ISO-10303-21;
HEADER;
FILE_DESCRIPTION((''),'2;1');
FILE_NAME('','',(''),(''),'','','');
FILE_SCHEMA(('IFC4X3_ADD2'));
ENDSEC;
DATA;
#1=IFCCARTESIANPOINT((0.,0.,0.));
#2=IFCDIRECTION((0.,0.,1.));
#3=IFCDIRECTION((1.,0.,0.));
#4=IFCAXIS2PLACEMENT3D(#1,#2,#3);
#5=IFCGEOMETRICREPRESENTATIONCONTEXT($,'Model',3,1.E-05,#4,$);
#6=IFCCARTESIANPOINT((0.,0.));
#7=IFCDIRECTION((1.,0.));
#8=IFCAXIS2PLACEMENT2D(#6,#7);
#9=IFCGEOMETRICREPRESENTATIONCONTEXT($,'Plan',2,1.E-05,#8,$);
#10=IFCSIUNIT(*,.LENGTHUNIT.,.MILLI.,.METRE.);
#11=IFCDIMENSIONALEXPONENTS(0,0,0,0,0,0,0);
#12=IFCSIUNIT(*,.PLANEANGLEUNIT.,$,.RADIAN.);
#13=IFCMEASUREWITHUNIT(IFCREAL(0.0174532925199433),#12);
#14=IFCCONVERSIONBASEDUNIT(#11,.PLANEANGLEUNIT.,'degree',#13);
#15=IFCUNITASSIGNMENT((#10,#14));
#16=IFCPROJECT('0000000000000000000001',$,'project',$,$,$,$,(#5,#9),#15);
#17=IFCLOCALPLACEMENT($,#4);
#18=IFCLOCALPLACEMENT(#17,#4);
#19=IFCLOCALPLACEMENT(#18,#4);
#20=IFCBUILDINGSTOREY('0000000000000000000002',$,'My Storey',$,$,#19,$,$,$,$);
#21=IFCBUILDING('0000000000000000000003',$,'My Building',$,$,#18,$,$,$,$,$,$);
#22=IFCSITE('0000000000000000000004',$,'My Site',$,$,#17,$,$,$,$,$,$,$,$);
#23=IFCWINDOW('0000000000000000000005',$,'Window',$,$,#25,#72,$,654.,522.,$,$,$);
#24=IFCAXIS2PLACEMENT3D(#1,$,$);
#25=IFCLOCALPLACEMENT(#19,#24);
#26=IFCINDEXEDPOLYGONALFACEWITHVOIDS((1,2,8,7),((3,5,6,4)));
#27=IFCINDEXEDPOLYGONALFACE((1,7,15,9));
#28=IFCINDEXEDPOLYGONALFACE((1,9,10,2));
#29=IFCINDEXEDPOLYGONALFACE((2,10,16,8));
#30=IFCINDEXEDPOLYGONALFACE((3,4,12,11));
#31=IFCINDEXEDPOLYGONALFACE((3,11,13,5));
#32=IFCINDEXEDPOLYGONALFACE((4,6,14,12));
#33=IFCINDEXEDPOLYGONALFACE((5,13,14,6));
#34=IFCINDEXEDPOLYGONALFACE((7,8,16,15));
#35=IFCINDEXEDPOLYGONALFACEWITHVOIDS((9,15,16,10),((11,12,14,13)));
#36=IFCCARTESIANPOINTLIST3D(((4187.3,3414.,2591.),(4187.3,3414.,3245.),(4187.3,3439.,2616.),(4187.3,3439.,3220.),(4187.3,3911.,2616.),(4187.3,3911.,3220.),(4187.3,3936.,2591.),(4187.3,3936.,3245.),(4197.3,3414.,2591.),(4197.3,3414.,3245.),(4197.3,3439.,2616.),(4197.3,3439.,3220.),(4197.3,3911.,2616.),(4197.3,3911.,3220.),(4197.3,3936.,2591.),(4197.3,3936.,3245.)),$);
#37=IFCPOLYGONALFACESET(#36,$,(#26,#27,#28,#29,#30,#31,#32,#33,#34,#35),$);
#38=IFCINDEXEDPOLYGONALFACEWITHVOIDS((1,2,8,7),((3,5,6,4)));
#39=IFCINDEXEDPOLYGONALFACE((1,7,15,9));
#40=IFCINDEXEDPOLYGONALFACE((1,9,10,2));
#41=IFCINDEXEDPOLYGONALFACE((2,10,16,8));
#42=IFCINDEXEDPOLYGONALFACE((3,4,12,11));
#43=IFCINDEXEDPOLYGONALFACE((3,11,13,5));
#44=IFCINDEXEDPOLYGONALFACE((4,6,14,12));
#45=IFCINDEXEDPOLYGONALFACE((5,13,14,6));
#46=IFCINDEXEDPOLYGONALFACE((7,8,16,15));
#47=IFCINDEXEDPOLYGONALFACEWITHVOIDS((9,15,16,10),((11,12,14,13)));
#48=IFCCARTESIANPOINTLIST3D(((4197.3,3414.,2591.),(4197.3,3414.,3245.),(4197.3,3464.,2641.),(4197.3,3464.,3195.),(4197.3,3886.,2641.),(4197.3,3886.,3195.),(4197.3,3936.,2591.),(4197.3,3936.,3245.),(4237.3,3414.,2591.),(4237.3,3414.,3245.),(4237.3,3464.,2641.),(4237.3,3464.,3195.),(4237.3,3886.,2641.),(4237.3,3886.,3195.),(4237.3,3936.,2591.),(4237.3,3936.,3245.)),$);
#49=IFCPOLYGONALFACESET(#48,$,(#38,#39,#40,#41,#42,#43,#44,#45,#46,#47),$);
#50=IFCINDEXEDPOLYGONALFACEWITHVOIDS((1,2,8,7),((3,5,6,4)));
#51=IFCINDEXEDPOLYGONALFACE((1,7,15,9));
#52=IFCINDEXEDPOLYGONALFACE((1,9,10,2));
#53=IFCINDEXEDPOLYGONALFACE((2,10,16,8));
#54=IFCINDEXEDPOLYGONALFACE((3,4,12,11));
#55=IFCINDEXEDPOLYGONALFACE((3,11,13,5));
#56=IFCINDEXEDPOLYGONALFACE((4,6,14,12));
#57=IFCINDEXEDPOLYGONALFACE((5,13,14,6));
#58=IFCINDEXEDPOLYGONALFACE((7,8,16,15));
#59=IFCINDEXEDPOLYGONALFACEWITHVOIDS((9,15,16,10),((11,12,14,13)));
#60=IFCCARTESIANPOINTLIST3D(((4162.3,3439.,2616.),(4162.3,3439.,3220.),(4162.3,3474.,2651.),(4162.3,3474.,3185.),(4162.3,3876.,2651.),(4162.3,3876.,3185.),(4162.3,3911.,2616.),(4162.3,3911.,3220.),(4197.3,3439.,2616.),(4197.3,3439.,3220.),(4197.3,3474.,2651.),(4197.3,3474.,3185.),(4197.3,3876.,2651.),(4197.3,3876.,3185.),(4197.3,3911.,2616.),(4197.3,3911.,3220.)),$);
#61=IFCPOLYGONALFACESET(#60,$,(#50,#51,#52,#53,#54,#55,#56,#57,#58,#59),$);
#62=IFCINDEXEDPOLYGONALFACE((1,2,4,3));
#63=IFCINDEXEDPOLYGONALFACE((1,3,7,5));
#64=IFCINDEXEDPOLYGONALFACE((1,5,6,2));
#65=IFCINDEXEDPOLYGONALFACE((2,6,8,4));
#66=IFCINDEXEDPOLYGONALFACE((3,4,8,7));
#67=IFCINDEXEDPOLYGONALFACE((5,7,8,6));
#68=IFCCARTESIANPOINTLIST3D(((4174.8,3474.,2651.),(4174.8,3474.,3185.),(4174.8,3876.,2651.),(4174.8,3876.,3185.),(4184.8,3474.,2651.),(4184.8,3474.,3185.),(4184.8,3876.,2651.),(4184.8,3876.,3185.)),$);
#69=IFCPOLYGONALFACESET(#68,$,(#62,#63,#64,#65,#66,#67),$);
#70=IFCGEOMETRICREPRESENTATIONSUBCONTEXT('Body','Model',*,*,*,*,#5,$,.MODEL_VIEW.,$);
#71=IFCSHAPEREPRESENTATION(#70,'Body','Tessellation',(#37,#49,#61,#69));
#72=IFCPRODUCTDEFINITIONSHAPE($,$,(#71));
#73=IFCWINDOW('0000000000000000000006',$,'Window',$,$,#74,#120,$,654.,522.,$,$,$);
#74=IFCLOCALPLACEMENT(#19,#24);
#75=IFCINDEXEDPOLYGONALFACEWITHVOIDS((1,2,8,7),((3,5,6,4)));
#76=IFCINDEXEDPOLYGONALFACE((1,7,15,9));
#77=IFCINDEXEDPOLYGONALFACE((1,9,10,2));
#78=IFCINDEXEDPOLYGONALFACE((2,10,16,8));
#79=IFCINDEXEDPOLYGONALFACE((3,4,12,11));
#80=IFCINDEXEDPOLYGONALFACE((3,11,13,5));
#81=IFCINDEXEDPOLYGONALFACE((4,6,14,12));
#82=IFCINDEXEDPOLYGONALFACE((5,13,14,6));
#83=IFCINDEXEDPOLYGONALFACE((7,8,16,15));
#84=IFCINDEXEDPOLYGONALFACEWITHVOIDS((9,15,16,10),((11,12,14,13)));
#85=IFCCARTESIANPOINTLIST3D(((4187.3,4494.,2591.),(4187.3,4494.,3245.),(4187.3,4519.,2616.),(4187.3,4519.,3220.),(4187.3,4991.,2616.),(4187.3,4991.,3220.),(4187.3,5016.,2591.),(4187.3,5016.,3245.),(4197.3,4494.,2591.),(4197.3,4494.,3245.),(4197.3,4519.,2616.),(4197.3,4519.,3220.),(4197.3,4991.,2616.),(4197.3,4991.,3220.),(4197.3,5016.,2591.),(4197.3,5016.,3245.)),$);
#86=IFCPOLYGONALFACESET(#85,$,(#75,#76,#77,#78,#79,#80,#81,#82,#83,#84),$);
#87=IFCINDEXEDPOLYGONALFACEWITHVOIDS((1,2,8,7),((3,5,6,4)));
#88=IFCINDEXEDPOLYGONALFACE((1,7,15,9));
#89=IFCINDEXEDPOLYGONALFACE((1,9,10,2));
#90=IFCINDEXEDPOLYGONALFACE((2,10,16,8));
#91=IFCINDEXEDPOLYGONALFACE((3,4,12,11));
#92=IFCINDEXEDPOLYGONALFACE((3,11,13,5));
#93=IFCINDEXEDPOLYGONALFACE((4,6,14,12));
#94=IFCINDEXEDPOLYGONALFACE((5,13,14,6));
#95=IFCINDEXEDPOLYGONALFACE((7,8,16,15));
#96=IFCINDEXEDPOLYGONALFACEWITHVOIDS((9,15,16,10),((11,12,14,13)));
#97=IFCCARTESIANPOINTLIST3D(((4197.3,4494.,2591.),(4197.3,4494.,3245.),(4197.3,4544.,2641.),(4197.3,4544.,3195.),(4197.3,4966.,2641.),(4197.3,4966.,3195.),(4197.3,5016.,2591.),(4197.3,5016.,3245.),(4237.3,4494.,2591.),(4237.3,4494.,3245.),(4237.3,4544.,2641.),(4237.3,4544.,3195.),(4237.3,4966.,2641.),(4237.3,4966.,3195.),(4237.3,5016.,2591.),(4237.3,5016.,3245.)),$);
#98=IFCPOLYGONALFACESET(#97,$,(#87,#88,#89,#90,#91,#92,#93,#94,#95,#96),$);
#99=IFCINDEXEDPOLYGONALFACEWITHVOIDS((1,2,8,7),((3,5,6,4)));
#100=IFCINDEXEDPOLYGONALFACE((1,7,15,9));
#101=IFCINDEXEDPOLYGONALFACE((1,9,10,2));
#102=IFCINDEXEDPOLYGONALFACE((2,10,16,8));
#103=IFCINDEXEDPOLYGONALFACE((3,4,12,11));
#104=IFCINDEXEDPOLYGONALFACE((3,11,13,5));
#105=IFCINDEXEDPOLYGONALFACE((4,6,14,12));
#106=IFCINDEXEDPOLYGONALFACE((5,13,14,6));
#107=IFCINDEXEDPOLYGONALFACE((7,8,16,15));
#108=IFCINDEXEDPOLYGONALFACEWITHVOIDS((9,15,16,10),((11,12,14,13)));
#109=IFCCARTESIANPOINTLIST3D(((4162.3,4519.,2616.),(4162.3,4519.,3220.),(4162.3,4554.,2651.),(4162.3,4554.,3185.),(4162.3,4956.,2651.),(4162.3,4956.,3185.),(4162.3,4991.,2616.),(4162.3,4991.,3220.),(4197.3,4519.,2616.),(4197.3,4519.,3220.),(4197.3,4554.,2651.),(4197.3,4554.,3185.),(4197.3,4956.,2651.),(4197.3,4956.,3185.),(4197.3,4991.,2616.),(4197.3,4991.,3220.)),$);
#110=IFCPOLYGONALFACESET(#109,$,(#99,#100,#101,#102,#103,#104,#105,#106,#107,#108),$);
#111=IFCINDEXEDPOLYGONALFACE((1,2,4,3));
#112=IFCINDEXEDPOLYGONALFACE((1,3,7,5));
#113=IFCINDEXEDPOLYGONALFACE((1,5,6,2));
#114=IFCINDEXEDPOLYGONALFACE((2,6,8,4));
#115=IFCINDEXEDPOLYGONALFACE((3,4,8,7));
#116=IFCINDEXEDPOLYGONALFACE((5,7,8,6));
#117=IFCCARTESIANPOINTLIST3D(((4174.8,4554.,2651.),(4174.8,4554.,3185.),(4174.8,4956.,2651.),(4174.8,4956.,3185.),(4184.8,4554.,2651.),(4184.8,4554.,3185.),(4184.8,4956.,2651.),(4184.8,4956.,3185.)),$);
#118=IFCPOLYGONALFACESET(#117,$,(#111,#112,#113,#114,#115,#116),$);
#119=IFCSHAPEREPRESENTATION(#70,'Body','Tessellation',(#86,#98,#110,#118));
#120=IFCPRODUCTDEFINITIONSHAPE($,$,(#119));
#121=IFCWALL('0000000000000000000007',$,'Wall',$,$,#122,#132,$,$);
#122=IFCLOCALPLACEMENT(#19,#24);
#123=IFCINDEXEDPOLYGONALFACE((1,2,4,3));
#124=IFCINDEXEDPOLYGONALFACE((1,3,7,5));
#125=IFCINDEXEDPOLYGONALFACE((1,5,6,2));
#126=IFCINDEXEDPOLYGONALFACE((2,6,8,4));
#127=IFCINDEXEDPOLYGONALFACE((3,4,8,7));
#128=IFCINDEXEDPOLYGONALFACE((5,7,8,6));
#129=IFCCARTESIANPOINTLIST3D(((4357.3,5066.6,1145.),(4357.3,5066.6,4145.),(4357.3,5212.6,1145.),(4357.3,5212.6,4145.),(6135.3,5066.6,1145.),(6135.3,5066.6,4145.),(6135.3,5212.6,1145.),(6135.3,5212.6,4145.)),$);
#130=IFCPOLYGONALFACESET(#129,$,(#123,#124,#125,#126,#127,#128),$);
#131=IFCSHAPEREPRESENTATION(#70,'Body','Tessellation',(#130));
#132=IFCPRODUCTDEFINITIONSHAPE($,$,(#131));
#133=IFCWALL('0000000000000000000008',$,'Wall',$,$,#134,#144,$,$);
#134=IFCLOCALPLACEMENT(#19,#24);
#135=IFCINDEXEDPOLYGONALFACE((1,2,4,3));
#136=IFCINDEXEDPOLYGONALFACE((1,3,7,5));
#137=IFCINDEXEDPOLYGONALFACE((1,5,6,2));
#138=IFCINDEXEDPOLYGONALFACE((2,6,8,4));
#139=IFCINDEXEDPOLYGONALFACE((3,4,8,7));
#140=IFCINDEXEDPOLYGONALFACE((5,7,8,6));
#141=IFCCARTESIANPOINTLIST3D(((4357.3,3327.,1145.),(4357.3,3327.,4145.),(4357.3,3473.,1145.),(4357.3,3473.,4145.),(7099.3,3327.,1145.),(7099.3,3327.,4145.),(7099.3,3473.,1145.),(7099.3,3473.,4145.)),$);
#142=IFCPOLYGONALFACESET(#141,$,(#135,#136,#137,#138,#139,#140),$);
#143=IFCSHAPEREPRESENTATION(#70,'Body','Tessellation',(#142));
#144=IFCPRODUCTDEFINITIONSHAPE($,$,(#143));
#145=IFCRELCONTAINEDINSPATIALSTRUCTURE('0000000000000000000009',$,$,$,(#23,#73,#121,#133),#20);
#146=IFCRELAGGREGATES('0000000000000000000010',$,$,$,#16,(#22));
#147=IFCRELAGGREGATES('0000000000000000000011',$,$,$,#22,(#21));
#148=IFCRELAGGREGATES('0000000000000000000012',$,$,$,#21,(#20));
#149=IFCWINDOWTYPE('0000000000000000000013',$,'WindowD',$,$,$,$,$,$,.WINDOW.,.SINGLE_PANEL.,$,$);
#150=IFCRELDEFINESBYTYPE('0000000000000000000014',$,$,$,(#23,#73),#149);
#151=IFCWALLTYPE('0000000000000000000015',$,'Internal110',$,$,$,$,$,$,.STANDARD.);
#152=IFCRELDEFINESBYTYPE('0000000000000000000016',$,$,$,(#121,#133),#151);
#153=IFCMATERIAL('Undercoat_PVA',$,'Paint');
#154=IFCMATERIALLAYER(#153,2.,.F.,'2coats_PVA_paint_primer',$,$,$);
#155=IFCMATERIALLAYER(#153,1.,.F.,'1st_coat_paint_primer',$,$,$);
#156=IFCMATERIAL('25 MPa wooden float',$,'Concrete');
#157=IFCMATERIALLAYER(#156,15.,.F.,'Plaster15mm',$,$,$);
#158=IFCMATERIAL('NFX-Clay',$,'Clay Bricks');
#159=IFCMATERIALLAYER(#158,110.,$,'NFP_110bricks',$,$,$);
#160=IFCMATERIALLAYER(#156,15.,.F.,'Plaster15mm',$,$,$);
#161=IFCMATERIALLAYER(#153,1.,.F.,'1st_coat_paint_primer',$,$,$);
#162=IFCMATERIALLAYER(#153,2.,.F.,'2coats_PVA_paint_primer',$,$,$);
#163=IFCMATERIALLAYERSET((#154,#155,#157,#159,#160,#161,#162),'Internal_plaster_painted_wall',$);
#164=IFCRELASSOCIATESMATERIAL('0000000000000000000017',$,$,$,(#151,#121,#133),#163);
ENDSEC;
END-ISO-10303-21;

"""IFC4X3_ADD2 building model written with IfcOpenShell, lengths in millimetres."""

from ifc_helpers import new_model, entity, si_unit, converted_unit, frame, origin_with_axes, origin_2d_with_axis, place, context, subcontext, project, spatial, line, indexed_curve, outline, extrude, shape, source, transform, mapped, material, layer, layer_set, layer_usage, type_object, type_shapes, element, save


model = new_model("IFC4X3_ADD2")

# Units and contexts
model_context = context("Model", 3, precision=1e-05, world=origin_with_axes())
plan_context = context("Plan", 2, precision=1e-05, world=origin_2d_with_axis())
body_context_1 = subcontext(model_context, "Body", "Model", "MODEL_VIEW")
body_context_2 = subcontext(plan_context, "Body", "Plan", "PLAN_VIEW")
ifc_project = project(units=[si_unit("LENGTHUNIT", "METRE", prefix="MILLI"), converted_unit("PLANEANGLEUNIT", "degree", entity("IfcReal", 0.0174532925199433), si_unit("PLANEANGLEUNIT", "RADIAN"), dimensions=[0, 0, 0, 0, 0, 0, 0])], contexts=[model_context, plan_context])

# Site, building, storey
site_placement = place(None, origin_with_axes())
site = spatial("IfcSite", under=ifc_project, at=site_placement, Name="My Site")
building_placement = place(site_placement, origin_with_axes())
building = spatial("IfcBuilding", under=site, at=building_placement, Name="My Building")
storey_placement = place(building_placement, origin_with_axes())
storey = spatial("IfcBuildingStorey", under=building, at=storey_placement, Name="My Storey")

# Shared definitions
ifc_material_1 = material(Name="25 MPa wooden float", Category="Concrete")

# Windows
window_type_1 = type_object("IfcWindowType", Name="WindowD", PartitioningType="SINGLE_PANEL", PredefinedType="WINDOW")
shared_shape_1 = source(origin_with_axes(), body_context_1, "Body", "SweptSolid", [
    extrude(outline(indexed_curve([(0.0, 0.0), (522.0, 0.0), (522.0, 654.0), (0.0, 654.0)], segments=[line(1, 2, 3, 4, 1)]), holes=[indexed_curve([(25.0, 25.0), (497.0, 25.0), (497.0, 629.0), (25.0, 629.0)], segments=[line(1, 2, 3, 4, 1)])]), frame((0.0, 90.0, 0.0), z_axis=(0.0, -1.0, 0.0), x_axis=(1.0, 0.0, 0.0)), (0.0, 0.0, -1.0), 10.0),
    extrude(outline(indexed_curve([(0.0, 0.0), (522.0, 0.0), (522.0, 654.0), (0.0, 654.0)], segments=[line(1, 2, 3, 4, 1)]), holes=[indexed_curve([(50.0, 50.0), (472.0, 50.0), (472.0, 604.0), (50.0, 604.0)], segments=[line(1, 2, 3, 4, 1)])]), frame((0.0, 50.0, 0.0), z_axis=(0.0, -1.0, 0.0), x_axis=(1.0, 0.0, 0.0)), (0.0, 0.0, -1.0), 40.0),
    extrude(outline(indexed_curve([(0.0, 0.0), (472.0, 0.0), (472.0, 604.0), (0.0, 604.0)], segments=[line(1, 2, 3, 4, 1)]), holes=[indexed_curve([(35.0, 35.0), (437.0, 35.0), (437.0, 569.0), (35.0, 569.0)], segments=[line(1, 2, 3, 4, 1)])]), frame((25.0, 90.0, 25.0), z_axis=(0.0, -1.0, 0.0), x_axis=(1.0, 0.0, 0.0)), (0.0, 0.0, -1.0), 35.0),
    extrude(outline(indexed_curve([(35.0, 35.0), (437.0, 35.0), (437.0, 569.0), (35.0, 569.0)], segments=[line(1, 2, 3, 4, 1)])), frame((25.0, 102.5, 25.0), z_axis=(0.0, -1.0, 0.0), x_axis=(1.0, 0.0, 0.0)), (0.0, 0.0, -1.0), 10.0),
])
shared_shape_2 = source(origin_with_axes(), body_context_2, "Body", "Curve2D", [
    entity("IfcIndexedPolyCurve", entity("IfcCartesianPointList2D", [[50.0, 50.0], [472.0, 50.0]])),
    entity("IfcIndexedPolyCurve", entity("IfcCartesianPointList2D", [[0.0, 100.0], [25.0, 100.0], [25.0, 90.0], [50.0, 90.0], [50.0, 50.0], [0.0, 50.0]]), [entity("IfcLineIndex", [1, 2, 3, 4, 5, 6, 1])]),
    entity("IfcIndexedPolyCurve", entity("IfcCartesianPointList2D", [[522.0, 100.0], [497.0, 100.0], [497.0, 90.0], [472.0, 90.0], [472.0, 50.0], [522.0, 50.0]]), [entity("IfcLineIndex", [1, 2, 3, 4, 5, 6, 1])]),
    entity("IfcIndexedPolyCurve", entity("IfcCartesianPointList2D", [[25.0, 90.0], [60.0, 90.0], [60.0, 125.0], [25.0, 125.0]]), [entity("IfcLineIndex", [1, 2, 3, 4, 1])]),
    entity("IfcIndexedPolyCurve", entity("IfcCartesianPointList2D", [[497.0, 90.0], [462.0, 90.0], [462.0, 125.0], [497.0, 125.0]]), [entity("IfcLineIndex", [1, 2, 3, 4, 1])]),
    entity("IfcIndexedPolyCurve", entity("IfcCartesianPointList2D", [[60.0, 90.0], [462.0, 90.0]])),
    entity("IfcIndexedPolyCurve", entity("IfcCartesianPointList2D", [[60.0, 125.0], [462.0, 125.0]])),
    entity("IfcIndexedPolyCurve", entity("IfcCartesianPointList2D", [[60.0, 107.5], [462.0, 107.5]])),
])
type_shapes(window_type_1, [shared_shape_1, shared_shape_2])
for number, where, z_axis, x_axis, name in (
    (1, (4287.3, 3414.0, 2591.0), (0.0, 0.0, 1.0), (0.0, 1.0, 0.0), "Window"),
    (2, (4287.3, 4494.0, 2591.0), (0.0, 0.0, 1.0), (0.0, 1.0, 0.0), "Window"),
):
    element("IfcWindow", number, at=place(storey_placement, frame(where, z_axis=z_axis, x_axis=x_axis)), inside=storey, type_object=window_type_1, Name=name, OverallHeight=654.0, OverallWidth=522.0, shapes=[
        shape(body_context_1, "Body", "MappedRepresentation", [mapped(shared_shape_1, transform((0.0, 0.0, 0.0), x_axis=(1.0, 0.0, 0.0), y_axis=(0.0, 1.0, 0.0), z_axis=(0.0, 0.0, 1.0), scale=1.0))]),
        shape(body_context_2, "Body", "MappedRepresentation", [mapped(shared_shape_2, transform((0.0, 0.0, 0.0), x_axis=(1.0, 0.0, 0.0), y_axis=(0.0, 1.0, 0.0), z_axis=(0.0, 0.0, 1.0), scale=1.0))]),
    ])

# Walls
ifc_material_2 = material(Name="Undercoat_PVA", Category="Paint")
ifc_layer_1 = layer(ifc_material_2, 2.0, ventilated=False, Name="2coats_PVA_paint_primer")
ifc_layer_2 = layer(ifc_material_2, 1.0, ventilated=False, Name="1st_coat_paint_primer")
ifc_layer_3 = layer(ifc_material_1, 15.0, ventilated=False, Name="Plaster15mm")
ifc_material_3 = material(Name="NFX-Clay", Category="Clay Bricks")
ifc_layer_4 = layer(ifc_material_3, 110.0, Name="NFP_110bricks")
ifc_layer_5 = layer(ifc_material_1, 15.0, ventilated=False, Name="Plaster15mm")
ifc_layer_6 = layer(ifc_material_2, 1.0, ventilated=False, Name="1st_coat_paint_primer")
ifc_layer_7 = layer(ifc_material_2, 2.0, ventilated=False, Name="2coats_PVA_paint_primer")
ifc_layer_set_1 = layer_set([ifc_layer_1, ifc_layer_2, ifc_layer_3, ifc_layer_4, ifc_layer_5, ifc_layer_6, ifc_layer_7], Name="Internal_plaster_painted_wall")
ifc_layer_usage_1 = layer_usage(ifc_layer_set_1, "AXIS2", "POSITIVE", 0.0)
wall_type_1 = type_object("IfcWallType", Name="Internal110", PredefinedType="STANDARD", material=ifc_layer_set_1)
wall_1_placement = place(storey_placement, frame((6135.3, 5212.6, 1145.0), z_axis=(0.0, 0.0, 1.0), x_axis=(-1.0, -0.000001, 0.0)))
element("IfcWall", 3, at=wall_1_placement, inside=storey, type_object=wall_type_1, material=ifc_layer_usage_1, Name="Wall", context=body_context_1, shape_type="SweptSolid", body=[
    extrude(outline(indexed_curve([(0.0, 0.0), (0.0, 146.0), (1778.0, 146.0), (1778.0, 0.0)], segments=[line(1, 2, 3, 4, 1)])), origin_with_axes(), (0.0, 0.0, 1.0), 3000.0),
])
ifc_layer_usage_2 = layer_usage(ifc_layer_set_1, "AXIS2", "POSITIVE", 0.0)
wall_2_placement = place(storey_placement, frame((4357.3, 3327.0, 1145.0), z_axis=(0.0, 0.0, 1.0), x_axis=(1.0, 0.0, 0.0)))
element("IfcWall", 4, at=wall_2_placement, inside=storey, type_object=wall_type_1, material=ifc_layer_usage_2, Name="Wall", context=body_context_1, shape_type="SweptSolid", body=[
    extrude(outline(indexed_curve([(0.0, 0.0), (0.0, 146.0), (2742.0, 146.0), (2742.0, 0.0)], segments=[line(1, 2, 3, 4, 1)])), origin_with_axes(), (0.0, 0.0, 1.0), 3000.0),
])

save(model, "model.ifc")
